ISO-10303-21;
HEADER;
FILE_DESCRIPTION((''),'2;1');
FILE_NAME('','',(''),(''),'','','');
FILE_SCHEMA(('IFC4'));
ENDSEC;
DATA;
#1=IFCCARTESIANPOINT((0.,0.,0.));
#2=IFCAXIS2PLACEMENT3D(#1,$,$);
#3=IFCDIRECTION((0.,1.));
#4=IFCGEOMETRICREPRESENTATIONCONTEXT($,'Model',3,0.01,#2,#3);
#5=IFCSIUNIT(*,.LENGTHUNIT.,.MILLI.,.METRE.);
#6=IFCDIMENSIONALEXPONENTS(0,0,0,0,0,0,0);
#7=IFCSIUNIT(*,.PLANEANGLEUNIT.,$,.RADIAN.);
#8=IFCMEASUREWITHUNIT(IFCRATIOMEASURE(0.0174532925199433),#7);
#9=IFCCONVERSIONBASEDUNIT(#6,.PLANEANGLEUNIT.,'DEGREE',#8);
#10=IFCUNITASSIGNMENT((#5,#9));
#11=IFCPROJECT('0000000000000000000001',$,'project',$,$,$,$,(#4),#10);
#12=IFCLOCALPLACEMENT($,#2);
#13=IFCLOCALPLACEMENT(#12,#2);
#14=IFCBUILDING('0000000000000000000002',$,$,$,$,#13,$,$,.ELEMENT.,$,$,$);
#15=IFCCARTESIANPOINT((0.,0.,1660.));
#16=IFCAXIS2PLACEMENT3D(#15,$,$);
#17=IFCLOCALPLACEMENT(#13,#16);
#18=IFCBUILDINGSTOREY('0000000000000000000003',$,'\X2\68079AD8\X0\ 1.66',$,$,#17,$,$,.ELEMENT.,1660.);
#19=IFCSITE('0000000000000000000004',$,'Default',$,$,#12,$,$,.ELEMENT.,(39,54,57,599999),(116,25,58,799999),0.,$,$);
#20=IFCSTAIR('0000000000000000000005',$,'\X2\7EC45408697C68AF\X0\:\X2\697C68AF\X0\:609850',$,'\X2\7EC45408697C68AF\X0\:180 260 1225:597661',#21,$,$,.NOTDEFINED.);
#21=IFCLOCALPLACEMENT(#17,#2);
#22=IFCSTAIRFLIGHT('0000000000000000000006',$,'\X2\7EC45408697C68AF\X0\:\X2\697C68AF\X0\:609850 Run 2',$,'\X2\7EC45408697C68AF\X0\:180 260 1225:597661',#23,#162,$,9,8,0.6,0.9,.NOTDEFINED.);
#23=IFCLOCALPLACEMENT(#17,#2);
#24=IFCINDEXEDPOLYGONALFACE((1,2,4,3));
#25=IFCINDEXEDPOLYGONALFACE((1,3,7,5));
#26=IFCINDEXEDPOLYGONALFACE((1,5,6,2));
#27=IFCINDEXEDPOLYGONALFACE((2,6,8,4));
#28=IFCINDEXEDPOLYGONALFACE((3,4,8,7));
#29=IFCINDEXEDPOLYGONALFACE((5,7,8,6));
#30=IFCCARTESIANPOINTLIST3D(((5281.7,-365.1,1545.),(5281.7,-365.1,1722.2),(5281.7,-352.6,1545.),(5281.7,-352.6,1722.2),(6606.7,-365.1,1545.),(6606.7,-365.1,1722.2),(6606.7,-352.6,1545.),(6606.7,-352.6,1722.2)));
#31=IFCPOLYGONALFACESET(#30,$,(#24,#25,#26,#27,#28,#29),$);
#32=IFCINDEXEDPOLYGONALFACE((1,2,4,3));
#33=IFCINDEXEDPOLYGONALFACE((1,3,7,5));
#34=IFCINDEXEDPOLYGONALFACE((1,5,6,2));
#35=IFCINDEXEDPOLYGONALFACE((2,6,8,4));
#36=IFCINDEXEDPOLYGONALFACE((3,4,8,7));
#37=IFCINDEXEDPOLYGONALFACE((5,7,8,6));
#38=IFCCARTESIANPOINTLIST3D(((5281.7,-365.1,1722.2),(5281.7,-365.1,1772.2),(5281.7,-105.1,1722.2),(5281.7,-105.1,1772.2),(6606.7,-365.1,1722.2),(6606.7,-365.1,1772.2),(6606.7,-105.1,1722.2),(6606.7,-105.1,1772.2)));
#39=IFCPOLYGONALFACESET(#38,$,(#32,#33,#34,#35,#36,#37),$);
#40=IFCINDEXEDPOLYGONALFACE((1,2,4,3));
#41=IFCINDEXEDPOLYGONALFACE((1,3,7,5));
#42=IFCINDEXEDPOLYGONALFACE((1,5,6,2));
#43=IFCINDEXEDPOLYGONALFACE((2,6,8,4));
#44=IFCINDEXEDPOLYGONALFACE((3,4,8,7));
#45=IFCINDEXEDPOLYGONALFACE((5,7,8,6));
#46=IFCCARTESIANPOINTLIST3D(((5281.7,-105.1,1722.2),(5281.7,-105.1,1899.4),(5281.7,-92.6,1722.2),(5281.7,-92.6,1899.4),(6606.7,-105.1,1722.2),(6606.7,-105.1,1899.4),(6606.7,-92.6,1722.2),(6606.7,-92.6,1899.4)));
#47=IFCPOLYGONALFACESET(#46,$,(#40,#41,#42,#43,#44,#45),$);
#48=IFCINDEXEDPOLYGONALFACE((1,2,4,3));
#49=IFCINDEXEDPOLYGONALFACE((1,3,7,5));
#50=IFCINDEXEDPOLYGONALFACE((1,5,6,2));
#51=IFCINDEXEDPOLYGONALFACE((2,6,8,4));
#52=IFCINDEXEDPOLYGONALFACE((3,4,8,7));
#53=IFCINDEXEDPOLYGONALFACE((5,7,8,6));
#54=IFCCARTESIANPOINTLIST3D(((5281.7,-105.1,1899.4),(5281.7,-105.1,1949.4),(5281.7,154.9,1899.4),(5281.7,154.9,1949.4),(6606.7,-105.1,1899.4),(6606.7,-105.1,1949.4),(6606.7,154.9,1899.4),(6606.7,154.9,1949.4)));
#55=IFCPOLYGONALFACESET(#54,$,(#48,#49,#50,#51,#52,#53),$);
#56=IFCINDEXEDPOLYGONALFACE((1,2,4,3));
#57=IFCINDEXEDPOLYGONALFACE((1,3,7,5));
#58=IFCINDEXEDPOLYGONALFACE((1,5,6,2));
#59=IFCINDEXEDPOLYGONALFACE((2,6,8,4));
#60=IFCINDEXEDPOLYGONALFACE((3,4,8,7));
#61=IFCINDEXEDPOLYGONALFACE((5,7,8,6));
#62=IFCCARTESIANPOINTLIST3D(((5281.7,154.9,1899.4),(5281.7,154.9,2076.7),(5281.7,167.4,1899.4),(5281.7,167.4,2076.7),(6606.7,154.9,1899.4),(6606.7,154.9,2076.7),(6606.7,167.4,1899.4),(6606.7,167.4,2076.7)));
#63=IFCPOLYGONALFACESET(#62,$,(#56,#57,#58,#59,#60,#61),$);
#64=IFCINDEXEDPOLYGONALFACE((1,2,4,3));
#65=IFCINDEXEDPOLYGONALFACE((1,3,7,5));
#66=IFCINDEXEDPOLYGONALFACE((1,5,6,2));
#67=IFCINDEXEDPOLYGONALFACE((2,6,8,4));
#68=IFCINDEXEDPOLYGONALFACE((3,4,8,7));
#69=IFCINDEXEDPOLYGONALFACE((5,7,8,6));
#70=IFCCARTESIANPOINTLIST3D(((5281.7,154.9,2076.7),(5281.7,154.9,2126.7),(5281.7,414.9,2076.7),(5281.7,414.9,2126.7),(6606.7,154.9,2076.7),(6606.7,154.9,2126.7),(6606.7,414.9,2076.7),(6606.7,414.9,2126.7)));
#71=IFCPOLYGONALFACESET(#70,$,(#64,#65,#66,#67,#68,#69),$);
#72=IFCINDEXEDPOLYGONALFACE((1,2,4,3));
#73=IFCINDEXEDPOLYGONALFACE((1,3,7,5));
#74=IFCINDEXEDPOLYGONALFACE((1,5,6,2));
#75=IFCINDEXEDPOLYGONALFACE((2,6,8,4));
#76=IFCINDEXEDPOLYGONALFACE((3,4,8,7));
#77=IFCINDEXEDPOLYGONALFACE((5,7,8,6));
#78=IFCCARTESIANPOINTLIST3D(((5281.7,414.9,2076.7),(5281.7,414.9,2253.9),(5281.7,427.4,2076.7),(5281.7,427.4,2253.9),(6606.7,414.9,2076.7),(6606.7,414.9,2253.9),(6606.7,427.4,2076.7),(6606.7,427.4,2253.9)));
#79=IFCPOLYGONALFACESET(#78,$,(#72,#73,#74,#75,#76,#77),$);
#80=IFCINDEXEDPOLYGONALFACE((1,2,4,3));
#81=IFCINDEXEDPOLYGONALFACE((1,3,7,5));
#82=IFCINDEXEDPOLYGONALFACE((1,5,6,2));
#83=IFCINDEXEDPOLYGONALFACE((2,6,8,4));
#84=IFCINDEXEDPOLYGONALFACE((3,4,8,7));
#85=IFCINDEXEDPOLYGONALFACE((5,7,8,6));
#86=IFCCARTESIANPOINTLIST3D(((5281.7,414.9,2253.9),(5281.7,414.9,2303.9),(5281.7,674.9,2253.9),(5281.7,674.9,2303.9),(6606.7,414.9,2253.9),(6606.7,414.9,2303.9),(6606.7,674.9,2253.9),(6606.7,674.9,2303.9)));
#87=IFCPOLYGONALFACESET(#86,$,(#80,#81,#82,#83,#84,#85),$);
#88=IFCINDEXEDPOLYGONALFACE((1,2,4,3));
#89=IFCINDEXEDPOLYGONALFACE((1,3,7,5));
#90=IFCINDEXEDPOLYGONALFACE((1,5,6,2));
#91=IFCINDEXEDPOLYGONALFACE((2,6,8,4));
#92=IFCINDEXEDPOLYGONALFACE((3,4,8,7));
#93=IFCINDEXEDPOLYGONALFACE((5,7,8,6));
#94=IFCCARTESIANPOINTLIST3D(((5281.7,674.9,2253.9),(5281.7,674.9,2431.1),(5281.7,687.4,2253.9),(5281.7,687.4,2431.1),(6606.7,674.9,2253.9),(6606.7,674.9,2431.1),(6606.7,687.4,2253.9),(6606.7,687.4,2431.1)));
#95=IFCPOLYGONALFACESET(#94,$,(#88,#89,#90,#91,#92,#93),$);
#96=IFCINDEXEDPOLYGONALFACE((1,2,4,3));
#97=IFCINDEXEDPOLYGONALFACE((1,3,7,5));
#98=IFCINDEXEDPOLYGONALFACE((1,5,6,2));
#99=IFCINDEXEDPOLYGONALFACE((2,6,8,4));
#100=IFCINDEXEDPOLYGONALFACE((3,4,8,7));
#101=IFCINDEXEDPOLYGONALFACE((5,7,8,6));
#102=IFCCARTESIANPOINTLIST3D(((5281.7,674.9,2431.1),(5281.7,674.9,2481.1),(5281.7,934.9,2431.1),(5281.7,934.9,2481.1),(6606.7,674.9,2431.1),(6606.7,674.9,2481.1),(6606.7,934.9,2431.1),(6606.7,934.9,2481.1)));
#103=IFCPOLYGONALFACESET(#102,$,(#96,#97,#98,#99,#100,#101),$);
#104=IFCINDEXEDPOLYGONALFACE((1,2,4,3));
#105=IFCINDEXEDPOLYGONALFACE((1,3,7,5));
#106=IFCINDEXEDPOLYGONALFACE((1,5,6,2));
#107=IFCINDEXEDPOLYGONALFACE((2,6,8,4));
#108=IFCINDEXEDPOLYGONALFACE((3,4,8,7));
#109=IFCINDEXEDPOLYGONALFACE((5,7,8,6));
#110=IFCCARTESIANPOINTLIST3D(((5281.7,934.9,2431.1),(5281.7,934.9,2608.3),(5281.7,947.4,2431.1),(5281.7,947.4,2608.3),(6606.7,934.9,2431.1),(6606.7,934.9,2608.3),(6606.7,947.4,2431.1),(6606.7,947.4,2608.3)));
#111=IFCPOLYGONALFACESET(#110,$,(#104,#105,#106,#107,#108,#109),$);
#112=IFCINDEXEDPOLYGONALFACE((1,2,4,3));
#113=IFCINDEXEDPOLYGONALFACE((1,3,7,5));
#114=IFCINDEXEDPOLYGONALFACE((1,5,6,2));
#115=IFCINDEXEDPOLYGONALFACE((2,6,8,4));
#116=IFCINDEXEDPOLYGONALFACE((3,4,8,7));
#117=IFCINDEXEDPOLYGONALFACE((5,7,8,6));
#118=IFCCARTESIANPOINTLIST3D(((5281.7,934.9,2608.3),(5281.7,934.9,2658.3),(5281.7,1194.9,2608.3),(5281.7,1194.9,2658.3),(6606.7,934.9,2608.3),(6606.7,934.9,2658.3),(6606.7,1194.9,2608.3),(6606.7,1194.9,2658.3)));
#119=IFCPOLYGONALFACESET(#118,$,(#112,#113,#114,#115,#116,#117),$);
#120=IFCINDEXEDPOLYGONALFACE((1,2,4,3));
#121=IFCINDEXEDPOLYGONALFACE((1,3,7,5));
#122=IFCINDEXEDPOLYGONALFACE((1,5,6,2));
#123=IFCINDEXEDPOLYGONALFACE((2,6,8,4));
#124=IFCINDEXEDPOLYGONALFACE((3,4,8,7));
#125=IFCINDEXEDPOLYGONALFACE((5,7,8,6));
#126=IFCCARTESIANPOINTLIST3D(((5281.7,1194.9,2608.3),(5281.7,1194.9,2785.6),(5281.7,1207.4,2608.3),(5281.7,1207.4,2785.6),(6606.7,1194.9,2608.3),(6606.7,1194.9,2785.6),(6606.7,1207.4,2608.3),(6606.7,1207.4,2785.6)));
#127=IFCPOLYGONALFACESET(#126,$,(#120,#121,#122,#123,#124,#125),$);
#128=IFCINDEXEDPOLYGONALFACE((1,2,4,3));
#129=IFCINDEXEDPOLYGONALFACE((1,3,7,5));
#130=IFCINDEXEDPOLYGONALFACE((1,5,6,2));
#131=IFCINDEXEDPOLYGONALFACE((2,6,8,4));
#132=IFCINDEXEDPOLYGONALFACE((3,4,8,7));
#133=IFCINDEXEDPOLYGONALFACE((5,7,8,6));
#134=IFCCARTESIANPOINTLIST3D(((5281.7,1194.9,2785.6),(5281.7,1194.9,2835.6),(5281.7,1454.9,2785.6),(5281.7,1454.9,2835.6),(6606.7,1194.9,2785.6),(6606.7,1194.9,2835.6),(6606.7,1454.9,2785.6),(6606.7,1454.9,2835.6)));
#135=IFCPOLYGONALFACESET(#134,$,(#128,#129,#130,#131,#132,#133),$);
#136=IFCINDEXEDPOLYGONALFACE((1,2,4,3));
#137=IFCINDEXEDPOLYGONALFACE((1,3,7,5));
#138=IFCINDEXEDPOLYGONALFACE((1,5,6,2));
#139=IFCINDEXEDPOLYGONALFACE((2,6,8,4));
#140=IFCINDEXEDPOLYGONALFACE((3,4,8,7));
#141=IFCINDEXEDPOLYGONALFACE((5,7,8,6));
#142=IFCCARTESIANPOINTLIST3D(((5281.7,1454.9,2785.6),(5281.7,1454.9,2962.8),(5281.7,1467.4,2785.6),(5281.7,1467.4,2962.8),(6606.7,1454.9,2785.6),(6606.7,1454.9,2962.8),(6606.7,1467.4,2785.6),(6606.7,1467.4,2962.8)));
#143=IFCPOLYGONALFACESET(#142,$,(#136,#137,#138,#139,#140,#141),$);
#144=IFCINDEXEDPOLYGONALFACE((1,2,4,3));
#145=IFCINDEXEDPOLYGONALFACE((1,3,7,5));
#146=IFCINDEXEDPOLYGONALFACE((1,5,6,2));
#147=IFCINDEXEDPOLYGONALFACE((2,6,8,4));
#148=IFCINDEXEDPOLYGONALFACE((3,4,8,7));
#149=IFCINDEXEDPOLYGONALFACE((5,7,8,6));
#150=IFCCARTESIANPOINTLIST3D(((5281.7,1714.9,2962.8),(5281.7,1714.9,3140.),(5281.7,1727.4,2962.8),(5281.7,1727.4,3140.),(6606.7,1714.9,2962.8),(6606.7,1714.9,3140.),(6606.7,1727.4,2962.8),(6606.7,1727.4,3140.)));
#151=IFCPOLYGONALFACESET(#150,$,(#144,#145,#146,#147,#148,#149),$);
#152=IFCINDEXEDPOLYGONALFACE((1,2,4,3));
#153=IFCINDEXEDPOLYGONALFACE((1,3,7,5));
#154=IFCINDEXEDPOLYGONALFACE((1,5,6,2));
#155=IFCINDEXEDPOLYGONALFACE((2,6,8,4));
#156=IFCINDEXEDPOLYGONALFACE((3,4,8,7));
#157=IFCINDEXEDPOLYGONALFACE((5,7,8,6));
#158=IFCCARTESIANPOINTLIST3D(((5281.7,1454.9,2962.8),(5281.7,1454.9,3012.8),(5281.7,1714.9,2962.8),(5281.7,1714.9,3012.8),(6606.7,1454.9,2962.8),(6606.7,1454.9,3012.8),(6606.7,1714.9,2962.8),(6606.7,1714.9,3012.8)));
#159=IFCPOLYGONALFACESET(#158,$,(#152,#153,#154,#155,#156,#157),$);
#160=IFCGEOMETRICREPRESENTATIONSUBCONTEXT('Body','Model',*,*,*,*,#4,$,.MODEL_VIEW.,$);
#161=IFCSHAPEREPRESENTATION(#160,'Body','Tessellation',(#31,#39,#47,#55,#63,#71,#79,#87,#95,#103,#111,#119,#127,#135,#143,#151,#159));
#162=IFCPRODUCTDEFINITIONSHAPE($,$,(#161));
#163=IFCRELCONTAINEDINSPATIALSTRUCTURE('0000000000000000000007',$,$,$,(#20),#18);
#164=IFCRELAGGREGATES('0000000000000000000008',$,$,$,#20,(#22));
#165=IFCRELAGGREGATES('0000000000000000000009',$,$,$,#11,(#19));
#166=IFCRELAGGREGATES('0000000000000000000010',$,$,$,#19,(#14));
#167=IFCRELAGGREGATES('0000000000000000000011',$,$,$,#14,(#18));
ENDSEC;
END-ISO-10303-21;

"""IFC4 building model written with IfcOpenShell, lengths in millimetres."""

from ifc_helpers import new_model, entity, si_unit, converted_unit, direction, frame, frame_2d, origin, origin_2d_with_axis, place, context, subcontext, project, spatial, rectangle, extrude, element, aggregate, save


model = new_model("IFC4")

# Units and contexts
model_context = context("Model", 3, precision=0.01, world=origin(), true_north=direction((0.0, 1.0)))
body_context = subcontext(model_context, "Body", "Model", "MODEL_VIEW")
ifc_project = project(units=[si_unit("LENGTHUNIT", "METRE", prefix="MILLI"), converted_unit("PLANEANGLEUNIT", "DEGREE", entity("IfcRatioMeasure", 0.0174532925199433), si_unit("PLANEANGLEUNIT", "RADIAN"), dimensions=[0, 0, 0, 0, 0, 0, 0])], contexts=[model_context])

# Site, building, storey
site_placement = place(None, origin())
site = spatial("IfcSite", under=ifc_project, at=site_placement, Name="Default", CompositionType="ELEMENT", RefLatitude=(39, 54, 57, 599999), RefLongitude=(116, 25, 58, 799999), RefElevation=0.0)
building_placement = place(site_placement, origin())
building = spatial("IfcBuilding", under=site, at=building_placement, CompositionType="ELEMENT")
storey_placement = place(building_placement, frame((0.0, 0.0, 1660.0)))
storey = spatial("IfcBuildingStorey", under=building, at=storey_placement, Name="标高 1.66", CompositionType="ELEMENT", Elevation=1660.0)

# Stair, stair flight
stair_placement = place(storey_placement, origin())
stair = element("IfcStair", 1, at=stair_placement, inside=storey, Name="组合楼梯:楼梯:609850", ObjectType="组合楼梯:180 260 1225:597661", PredefinedType="NOTDEFINED")
stair_flight_1_placement = place(stair_placement, frame((5281.7, -365.1, 0.0)))
stair_flight_1 = element("IfcStairFlight", 2, at=stair_flight_1_placement, Name="组合楼梯:楼梯:609850 Run 2", ObjectType="组合楼梯:180 260 1225:597661", NumberOfRisers=9, NumberOfTreads=8, PredefinedType="NOTDEFINED", RiserHeight=0.6, TreadLength=0.9, context=body_context, shape_type="SweptSolid", body=[
    extrude(rectangle(XDim=1325.0, YDim=12.5, at=origin_2d_with_axis()), frame((662.5, 6.2, 1545.0), z_axis=(0.0, 0.0, 1.0), x_axis=(-1.0, 0.0, 0.0)), (0.0, 0.0, 1.0), 177.2),
    extrude(rectangle(XDim=260.0, YDim=1325.0, at=frame_2d((0.0, 0.0), x_axis=(1.0, 0.0))), frame((662.5, 130.0, 1722.2), z_axis=(0.0, 0.0, 1.0), x_axis=(0.0, -1.0, 0.0)), (0.0, 0.0, 1.0), 50.0),
    extrude(rectangle(XDim=1325.0, YDim=12.5, at=origin_2d_with_axis()), frame((662.5, 266.2, 1722.2), z_axis=(0.0, 0.0, 1.0), x_axis=(-1.0, 0.0, 0.0)), (0.0, 0.0, 1.0), 177.2),
    extrude(rectangle(XDim=260.0, YDim=1325.0, at=frame_2d((0.0, 0.0), x_axis=(1.0, 0.0))), frame((662.5, 390.0, 1899.4), z_axis=(0.0, 0.0, 1.0), x_axis=(0.0, -1.0, 0.0)), (0.0, 0.0, 1.0), 50.0),
    extrude(rectangle(XDim=1325.0, YDim=12.5, at=origin_2d_with_axis()), frame((662.5, 526.2, 1899.4), z_axis=(0.0, 0.0, 1.0), x_axis=(-1.0, 0.0, 0.0)), (0.0, 0.0, 1.0), 177.2),
    extrude(rectangle(XDim=260.0, YDim=1325.0, at=frame_2d((0.0, 0.0), x_axis=(1.0, 0.0))), frame((662.5, 650.0, 2076.7), z_axis=(0.0, 0.0, 1.0), x_axis=(0.0, -1.0, 0.0)), (0.0, 0.0, 1.0), 50.0),
    extrude(rectangle(XDim=1325.0, YDim=12.5, at=frame_2d((0.0, 0.0), x_axis=(1.0, 0.0))), frame((662.5, 786.2, 2076.7), z_axis=(0.0, 0.0, 1.0), x_axis=(-1.0, 0.0, 0.0)), (0.0, 0.0, 1.0), 177.2),
    extrude(rectangle(XDim=260.0, YDim=1325.0, at=frame_2d((0.0, 0.0), x_axis=(1.0, 0.0))), frame((662.5, 910.0, 2253.9), z_axis=(0.0, 0.0, 1.0), x_axis=(0.0, -1.0, 0.0)), (0.0, 0.0, 1.0), 50.0),
    extrude(rectangle(XDim=1325.0, YDim=12.5, at=frame_2d((0.0, 0.0), x_axis=(1.0, 0.0))), frame((662.5, 1046.2, 2253.9), z_axis=(0.0, 0.0, 1.0), x_axis=(-1.0, 0.0, 0.0)), (0.0, 0.0, 1.0), 177.2),
    extrude(rectangle(XDim=260.0, YDim=1325.0, at=frame_2d((0.0, 0.0), x_axis=(1.0, 0.0))), frame((662.5, 1170.0, 2431.1), z_axis=(0.0, 0.0, 1.0), x_axis=(0.0, -1.0, 0.0)), (0.0, 0.0, 1.0), 50.0),
    extrude(rectangle(XDim=1325.0, YDim=12.5, at=frame_2d((0.0, 0.0), x_axis=(1.0, 0.0))), frame((662.5, 1306.2, 2431.1), z_axis=(0.0, 0.0, 1.0), x_axis=(-1.0, 0.0, 0.0)), (0.0, 0.0, 1.0), 177.2),
    extrude(rectangle(XDim=260.0, YDim=1325.0, at=frame_2d((0.0, 0.0), x_axis=(1.0, 0.0))), frame((662.5, 1430.0, 2608.3), z_axis=(0.0, 0.0, 1.0), x_axis=(0.0, -1.0, 0.0)), (0.0, 0.0, 1.0), 50.0),
    extrude(rectangle(XDim=1325.0, YDim=12.5, at=frame_2d((0.0, 0.0), x_axis=(1.0, 0.0))), frame((662.5, 1566.2, 2608.3), z_axis=(0.0, 0.0, 1.0), x_axis=(-1.0, 0.0, 0.0)), (0.0, 0.0, 1.0), 177.2),
    extrude(rectangle(XDim=260.0, YDim=1325.0, at=frame_2d((0.0, 0.0), x_axis=(1.0, 0.0))), frame((662.5, 1690.0, 2785.6), z_axis=(0.0, 0.0, 1.0), x_axis=(0.0, -1.0, 0.0)), (0.0, 0.0, 1.0), 50.0),
    extrude(rectangle(XDim=1325.0, YDim=12.5, at=frame_2d((0.0, 0.0), x_axis=(1.0, 0.0))), frame((662.5, 1826.2, 2785.6), z_axis=(0.0, 0.0, 1.0), x_axis=(-1.0, 0.0, 0.0)), (0.0, 0.0, 1.0), 177.2),
    extrude(rectangle(XDim=1325.0, YDim=12.5, at=frame_2d((0.0, 0.0), x_axis=(1.0, 0.0))), frame((662.5, 2086.2, 2962.8), z_axis=(0.0, 0.0, 1.0), x_axis=(-1.0, 0.0, 0.0)), (0.0, 0.0, 1.0), 177.2),
    extrude(rectangle(XDim=260.0, YDim=1325.0, at=frame_2d((0.0, 0.0), x_axis=(1.0, 0.0))), frame((662.5, 1950.0, 2962.8), z_axis=(0.0, 0.0, 1.0), x_axis=(0.0, -1.0, 0.0)), (0.0, 0.0, 1.0), 50.0),
])
aggregate(stair, [stair_flight_1])

save(model, "model.ifc")
